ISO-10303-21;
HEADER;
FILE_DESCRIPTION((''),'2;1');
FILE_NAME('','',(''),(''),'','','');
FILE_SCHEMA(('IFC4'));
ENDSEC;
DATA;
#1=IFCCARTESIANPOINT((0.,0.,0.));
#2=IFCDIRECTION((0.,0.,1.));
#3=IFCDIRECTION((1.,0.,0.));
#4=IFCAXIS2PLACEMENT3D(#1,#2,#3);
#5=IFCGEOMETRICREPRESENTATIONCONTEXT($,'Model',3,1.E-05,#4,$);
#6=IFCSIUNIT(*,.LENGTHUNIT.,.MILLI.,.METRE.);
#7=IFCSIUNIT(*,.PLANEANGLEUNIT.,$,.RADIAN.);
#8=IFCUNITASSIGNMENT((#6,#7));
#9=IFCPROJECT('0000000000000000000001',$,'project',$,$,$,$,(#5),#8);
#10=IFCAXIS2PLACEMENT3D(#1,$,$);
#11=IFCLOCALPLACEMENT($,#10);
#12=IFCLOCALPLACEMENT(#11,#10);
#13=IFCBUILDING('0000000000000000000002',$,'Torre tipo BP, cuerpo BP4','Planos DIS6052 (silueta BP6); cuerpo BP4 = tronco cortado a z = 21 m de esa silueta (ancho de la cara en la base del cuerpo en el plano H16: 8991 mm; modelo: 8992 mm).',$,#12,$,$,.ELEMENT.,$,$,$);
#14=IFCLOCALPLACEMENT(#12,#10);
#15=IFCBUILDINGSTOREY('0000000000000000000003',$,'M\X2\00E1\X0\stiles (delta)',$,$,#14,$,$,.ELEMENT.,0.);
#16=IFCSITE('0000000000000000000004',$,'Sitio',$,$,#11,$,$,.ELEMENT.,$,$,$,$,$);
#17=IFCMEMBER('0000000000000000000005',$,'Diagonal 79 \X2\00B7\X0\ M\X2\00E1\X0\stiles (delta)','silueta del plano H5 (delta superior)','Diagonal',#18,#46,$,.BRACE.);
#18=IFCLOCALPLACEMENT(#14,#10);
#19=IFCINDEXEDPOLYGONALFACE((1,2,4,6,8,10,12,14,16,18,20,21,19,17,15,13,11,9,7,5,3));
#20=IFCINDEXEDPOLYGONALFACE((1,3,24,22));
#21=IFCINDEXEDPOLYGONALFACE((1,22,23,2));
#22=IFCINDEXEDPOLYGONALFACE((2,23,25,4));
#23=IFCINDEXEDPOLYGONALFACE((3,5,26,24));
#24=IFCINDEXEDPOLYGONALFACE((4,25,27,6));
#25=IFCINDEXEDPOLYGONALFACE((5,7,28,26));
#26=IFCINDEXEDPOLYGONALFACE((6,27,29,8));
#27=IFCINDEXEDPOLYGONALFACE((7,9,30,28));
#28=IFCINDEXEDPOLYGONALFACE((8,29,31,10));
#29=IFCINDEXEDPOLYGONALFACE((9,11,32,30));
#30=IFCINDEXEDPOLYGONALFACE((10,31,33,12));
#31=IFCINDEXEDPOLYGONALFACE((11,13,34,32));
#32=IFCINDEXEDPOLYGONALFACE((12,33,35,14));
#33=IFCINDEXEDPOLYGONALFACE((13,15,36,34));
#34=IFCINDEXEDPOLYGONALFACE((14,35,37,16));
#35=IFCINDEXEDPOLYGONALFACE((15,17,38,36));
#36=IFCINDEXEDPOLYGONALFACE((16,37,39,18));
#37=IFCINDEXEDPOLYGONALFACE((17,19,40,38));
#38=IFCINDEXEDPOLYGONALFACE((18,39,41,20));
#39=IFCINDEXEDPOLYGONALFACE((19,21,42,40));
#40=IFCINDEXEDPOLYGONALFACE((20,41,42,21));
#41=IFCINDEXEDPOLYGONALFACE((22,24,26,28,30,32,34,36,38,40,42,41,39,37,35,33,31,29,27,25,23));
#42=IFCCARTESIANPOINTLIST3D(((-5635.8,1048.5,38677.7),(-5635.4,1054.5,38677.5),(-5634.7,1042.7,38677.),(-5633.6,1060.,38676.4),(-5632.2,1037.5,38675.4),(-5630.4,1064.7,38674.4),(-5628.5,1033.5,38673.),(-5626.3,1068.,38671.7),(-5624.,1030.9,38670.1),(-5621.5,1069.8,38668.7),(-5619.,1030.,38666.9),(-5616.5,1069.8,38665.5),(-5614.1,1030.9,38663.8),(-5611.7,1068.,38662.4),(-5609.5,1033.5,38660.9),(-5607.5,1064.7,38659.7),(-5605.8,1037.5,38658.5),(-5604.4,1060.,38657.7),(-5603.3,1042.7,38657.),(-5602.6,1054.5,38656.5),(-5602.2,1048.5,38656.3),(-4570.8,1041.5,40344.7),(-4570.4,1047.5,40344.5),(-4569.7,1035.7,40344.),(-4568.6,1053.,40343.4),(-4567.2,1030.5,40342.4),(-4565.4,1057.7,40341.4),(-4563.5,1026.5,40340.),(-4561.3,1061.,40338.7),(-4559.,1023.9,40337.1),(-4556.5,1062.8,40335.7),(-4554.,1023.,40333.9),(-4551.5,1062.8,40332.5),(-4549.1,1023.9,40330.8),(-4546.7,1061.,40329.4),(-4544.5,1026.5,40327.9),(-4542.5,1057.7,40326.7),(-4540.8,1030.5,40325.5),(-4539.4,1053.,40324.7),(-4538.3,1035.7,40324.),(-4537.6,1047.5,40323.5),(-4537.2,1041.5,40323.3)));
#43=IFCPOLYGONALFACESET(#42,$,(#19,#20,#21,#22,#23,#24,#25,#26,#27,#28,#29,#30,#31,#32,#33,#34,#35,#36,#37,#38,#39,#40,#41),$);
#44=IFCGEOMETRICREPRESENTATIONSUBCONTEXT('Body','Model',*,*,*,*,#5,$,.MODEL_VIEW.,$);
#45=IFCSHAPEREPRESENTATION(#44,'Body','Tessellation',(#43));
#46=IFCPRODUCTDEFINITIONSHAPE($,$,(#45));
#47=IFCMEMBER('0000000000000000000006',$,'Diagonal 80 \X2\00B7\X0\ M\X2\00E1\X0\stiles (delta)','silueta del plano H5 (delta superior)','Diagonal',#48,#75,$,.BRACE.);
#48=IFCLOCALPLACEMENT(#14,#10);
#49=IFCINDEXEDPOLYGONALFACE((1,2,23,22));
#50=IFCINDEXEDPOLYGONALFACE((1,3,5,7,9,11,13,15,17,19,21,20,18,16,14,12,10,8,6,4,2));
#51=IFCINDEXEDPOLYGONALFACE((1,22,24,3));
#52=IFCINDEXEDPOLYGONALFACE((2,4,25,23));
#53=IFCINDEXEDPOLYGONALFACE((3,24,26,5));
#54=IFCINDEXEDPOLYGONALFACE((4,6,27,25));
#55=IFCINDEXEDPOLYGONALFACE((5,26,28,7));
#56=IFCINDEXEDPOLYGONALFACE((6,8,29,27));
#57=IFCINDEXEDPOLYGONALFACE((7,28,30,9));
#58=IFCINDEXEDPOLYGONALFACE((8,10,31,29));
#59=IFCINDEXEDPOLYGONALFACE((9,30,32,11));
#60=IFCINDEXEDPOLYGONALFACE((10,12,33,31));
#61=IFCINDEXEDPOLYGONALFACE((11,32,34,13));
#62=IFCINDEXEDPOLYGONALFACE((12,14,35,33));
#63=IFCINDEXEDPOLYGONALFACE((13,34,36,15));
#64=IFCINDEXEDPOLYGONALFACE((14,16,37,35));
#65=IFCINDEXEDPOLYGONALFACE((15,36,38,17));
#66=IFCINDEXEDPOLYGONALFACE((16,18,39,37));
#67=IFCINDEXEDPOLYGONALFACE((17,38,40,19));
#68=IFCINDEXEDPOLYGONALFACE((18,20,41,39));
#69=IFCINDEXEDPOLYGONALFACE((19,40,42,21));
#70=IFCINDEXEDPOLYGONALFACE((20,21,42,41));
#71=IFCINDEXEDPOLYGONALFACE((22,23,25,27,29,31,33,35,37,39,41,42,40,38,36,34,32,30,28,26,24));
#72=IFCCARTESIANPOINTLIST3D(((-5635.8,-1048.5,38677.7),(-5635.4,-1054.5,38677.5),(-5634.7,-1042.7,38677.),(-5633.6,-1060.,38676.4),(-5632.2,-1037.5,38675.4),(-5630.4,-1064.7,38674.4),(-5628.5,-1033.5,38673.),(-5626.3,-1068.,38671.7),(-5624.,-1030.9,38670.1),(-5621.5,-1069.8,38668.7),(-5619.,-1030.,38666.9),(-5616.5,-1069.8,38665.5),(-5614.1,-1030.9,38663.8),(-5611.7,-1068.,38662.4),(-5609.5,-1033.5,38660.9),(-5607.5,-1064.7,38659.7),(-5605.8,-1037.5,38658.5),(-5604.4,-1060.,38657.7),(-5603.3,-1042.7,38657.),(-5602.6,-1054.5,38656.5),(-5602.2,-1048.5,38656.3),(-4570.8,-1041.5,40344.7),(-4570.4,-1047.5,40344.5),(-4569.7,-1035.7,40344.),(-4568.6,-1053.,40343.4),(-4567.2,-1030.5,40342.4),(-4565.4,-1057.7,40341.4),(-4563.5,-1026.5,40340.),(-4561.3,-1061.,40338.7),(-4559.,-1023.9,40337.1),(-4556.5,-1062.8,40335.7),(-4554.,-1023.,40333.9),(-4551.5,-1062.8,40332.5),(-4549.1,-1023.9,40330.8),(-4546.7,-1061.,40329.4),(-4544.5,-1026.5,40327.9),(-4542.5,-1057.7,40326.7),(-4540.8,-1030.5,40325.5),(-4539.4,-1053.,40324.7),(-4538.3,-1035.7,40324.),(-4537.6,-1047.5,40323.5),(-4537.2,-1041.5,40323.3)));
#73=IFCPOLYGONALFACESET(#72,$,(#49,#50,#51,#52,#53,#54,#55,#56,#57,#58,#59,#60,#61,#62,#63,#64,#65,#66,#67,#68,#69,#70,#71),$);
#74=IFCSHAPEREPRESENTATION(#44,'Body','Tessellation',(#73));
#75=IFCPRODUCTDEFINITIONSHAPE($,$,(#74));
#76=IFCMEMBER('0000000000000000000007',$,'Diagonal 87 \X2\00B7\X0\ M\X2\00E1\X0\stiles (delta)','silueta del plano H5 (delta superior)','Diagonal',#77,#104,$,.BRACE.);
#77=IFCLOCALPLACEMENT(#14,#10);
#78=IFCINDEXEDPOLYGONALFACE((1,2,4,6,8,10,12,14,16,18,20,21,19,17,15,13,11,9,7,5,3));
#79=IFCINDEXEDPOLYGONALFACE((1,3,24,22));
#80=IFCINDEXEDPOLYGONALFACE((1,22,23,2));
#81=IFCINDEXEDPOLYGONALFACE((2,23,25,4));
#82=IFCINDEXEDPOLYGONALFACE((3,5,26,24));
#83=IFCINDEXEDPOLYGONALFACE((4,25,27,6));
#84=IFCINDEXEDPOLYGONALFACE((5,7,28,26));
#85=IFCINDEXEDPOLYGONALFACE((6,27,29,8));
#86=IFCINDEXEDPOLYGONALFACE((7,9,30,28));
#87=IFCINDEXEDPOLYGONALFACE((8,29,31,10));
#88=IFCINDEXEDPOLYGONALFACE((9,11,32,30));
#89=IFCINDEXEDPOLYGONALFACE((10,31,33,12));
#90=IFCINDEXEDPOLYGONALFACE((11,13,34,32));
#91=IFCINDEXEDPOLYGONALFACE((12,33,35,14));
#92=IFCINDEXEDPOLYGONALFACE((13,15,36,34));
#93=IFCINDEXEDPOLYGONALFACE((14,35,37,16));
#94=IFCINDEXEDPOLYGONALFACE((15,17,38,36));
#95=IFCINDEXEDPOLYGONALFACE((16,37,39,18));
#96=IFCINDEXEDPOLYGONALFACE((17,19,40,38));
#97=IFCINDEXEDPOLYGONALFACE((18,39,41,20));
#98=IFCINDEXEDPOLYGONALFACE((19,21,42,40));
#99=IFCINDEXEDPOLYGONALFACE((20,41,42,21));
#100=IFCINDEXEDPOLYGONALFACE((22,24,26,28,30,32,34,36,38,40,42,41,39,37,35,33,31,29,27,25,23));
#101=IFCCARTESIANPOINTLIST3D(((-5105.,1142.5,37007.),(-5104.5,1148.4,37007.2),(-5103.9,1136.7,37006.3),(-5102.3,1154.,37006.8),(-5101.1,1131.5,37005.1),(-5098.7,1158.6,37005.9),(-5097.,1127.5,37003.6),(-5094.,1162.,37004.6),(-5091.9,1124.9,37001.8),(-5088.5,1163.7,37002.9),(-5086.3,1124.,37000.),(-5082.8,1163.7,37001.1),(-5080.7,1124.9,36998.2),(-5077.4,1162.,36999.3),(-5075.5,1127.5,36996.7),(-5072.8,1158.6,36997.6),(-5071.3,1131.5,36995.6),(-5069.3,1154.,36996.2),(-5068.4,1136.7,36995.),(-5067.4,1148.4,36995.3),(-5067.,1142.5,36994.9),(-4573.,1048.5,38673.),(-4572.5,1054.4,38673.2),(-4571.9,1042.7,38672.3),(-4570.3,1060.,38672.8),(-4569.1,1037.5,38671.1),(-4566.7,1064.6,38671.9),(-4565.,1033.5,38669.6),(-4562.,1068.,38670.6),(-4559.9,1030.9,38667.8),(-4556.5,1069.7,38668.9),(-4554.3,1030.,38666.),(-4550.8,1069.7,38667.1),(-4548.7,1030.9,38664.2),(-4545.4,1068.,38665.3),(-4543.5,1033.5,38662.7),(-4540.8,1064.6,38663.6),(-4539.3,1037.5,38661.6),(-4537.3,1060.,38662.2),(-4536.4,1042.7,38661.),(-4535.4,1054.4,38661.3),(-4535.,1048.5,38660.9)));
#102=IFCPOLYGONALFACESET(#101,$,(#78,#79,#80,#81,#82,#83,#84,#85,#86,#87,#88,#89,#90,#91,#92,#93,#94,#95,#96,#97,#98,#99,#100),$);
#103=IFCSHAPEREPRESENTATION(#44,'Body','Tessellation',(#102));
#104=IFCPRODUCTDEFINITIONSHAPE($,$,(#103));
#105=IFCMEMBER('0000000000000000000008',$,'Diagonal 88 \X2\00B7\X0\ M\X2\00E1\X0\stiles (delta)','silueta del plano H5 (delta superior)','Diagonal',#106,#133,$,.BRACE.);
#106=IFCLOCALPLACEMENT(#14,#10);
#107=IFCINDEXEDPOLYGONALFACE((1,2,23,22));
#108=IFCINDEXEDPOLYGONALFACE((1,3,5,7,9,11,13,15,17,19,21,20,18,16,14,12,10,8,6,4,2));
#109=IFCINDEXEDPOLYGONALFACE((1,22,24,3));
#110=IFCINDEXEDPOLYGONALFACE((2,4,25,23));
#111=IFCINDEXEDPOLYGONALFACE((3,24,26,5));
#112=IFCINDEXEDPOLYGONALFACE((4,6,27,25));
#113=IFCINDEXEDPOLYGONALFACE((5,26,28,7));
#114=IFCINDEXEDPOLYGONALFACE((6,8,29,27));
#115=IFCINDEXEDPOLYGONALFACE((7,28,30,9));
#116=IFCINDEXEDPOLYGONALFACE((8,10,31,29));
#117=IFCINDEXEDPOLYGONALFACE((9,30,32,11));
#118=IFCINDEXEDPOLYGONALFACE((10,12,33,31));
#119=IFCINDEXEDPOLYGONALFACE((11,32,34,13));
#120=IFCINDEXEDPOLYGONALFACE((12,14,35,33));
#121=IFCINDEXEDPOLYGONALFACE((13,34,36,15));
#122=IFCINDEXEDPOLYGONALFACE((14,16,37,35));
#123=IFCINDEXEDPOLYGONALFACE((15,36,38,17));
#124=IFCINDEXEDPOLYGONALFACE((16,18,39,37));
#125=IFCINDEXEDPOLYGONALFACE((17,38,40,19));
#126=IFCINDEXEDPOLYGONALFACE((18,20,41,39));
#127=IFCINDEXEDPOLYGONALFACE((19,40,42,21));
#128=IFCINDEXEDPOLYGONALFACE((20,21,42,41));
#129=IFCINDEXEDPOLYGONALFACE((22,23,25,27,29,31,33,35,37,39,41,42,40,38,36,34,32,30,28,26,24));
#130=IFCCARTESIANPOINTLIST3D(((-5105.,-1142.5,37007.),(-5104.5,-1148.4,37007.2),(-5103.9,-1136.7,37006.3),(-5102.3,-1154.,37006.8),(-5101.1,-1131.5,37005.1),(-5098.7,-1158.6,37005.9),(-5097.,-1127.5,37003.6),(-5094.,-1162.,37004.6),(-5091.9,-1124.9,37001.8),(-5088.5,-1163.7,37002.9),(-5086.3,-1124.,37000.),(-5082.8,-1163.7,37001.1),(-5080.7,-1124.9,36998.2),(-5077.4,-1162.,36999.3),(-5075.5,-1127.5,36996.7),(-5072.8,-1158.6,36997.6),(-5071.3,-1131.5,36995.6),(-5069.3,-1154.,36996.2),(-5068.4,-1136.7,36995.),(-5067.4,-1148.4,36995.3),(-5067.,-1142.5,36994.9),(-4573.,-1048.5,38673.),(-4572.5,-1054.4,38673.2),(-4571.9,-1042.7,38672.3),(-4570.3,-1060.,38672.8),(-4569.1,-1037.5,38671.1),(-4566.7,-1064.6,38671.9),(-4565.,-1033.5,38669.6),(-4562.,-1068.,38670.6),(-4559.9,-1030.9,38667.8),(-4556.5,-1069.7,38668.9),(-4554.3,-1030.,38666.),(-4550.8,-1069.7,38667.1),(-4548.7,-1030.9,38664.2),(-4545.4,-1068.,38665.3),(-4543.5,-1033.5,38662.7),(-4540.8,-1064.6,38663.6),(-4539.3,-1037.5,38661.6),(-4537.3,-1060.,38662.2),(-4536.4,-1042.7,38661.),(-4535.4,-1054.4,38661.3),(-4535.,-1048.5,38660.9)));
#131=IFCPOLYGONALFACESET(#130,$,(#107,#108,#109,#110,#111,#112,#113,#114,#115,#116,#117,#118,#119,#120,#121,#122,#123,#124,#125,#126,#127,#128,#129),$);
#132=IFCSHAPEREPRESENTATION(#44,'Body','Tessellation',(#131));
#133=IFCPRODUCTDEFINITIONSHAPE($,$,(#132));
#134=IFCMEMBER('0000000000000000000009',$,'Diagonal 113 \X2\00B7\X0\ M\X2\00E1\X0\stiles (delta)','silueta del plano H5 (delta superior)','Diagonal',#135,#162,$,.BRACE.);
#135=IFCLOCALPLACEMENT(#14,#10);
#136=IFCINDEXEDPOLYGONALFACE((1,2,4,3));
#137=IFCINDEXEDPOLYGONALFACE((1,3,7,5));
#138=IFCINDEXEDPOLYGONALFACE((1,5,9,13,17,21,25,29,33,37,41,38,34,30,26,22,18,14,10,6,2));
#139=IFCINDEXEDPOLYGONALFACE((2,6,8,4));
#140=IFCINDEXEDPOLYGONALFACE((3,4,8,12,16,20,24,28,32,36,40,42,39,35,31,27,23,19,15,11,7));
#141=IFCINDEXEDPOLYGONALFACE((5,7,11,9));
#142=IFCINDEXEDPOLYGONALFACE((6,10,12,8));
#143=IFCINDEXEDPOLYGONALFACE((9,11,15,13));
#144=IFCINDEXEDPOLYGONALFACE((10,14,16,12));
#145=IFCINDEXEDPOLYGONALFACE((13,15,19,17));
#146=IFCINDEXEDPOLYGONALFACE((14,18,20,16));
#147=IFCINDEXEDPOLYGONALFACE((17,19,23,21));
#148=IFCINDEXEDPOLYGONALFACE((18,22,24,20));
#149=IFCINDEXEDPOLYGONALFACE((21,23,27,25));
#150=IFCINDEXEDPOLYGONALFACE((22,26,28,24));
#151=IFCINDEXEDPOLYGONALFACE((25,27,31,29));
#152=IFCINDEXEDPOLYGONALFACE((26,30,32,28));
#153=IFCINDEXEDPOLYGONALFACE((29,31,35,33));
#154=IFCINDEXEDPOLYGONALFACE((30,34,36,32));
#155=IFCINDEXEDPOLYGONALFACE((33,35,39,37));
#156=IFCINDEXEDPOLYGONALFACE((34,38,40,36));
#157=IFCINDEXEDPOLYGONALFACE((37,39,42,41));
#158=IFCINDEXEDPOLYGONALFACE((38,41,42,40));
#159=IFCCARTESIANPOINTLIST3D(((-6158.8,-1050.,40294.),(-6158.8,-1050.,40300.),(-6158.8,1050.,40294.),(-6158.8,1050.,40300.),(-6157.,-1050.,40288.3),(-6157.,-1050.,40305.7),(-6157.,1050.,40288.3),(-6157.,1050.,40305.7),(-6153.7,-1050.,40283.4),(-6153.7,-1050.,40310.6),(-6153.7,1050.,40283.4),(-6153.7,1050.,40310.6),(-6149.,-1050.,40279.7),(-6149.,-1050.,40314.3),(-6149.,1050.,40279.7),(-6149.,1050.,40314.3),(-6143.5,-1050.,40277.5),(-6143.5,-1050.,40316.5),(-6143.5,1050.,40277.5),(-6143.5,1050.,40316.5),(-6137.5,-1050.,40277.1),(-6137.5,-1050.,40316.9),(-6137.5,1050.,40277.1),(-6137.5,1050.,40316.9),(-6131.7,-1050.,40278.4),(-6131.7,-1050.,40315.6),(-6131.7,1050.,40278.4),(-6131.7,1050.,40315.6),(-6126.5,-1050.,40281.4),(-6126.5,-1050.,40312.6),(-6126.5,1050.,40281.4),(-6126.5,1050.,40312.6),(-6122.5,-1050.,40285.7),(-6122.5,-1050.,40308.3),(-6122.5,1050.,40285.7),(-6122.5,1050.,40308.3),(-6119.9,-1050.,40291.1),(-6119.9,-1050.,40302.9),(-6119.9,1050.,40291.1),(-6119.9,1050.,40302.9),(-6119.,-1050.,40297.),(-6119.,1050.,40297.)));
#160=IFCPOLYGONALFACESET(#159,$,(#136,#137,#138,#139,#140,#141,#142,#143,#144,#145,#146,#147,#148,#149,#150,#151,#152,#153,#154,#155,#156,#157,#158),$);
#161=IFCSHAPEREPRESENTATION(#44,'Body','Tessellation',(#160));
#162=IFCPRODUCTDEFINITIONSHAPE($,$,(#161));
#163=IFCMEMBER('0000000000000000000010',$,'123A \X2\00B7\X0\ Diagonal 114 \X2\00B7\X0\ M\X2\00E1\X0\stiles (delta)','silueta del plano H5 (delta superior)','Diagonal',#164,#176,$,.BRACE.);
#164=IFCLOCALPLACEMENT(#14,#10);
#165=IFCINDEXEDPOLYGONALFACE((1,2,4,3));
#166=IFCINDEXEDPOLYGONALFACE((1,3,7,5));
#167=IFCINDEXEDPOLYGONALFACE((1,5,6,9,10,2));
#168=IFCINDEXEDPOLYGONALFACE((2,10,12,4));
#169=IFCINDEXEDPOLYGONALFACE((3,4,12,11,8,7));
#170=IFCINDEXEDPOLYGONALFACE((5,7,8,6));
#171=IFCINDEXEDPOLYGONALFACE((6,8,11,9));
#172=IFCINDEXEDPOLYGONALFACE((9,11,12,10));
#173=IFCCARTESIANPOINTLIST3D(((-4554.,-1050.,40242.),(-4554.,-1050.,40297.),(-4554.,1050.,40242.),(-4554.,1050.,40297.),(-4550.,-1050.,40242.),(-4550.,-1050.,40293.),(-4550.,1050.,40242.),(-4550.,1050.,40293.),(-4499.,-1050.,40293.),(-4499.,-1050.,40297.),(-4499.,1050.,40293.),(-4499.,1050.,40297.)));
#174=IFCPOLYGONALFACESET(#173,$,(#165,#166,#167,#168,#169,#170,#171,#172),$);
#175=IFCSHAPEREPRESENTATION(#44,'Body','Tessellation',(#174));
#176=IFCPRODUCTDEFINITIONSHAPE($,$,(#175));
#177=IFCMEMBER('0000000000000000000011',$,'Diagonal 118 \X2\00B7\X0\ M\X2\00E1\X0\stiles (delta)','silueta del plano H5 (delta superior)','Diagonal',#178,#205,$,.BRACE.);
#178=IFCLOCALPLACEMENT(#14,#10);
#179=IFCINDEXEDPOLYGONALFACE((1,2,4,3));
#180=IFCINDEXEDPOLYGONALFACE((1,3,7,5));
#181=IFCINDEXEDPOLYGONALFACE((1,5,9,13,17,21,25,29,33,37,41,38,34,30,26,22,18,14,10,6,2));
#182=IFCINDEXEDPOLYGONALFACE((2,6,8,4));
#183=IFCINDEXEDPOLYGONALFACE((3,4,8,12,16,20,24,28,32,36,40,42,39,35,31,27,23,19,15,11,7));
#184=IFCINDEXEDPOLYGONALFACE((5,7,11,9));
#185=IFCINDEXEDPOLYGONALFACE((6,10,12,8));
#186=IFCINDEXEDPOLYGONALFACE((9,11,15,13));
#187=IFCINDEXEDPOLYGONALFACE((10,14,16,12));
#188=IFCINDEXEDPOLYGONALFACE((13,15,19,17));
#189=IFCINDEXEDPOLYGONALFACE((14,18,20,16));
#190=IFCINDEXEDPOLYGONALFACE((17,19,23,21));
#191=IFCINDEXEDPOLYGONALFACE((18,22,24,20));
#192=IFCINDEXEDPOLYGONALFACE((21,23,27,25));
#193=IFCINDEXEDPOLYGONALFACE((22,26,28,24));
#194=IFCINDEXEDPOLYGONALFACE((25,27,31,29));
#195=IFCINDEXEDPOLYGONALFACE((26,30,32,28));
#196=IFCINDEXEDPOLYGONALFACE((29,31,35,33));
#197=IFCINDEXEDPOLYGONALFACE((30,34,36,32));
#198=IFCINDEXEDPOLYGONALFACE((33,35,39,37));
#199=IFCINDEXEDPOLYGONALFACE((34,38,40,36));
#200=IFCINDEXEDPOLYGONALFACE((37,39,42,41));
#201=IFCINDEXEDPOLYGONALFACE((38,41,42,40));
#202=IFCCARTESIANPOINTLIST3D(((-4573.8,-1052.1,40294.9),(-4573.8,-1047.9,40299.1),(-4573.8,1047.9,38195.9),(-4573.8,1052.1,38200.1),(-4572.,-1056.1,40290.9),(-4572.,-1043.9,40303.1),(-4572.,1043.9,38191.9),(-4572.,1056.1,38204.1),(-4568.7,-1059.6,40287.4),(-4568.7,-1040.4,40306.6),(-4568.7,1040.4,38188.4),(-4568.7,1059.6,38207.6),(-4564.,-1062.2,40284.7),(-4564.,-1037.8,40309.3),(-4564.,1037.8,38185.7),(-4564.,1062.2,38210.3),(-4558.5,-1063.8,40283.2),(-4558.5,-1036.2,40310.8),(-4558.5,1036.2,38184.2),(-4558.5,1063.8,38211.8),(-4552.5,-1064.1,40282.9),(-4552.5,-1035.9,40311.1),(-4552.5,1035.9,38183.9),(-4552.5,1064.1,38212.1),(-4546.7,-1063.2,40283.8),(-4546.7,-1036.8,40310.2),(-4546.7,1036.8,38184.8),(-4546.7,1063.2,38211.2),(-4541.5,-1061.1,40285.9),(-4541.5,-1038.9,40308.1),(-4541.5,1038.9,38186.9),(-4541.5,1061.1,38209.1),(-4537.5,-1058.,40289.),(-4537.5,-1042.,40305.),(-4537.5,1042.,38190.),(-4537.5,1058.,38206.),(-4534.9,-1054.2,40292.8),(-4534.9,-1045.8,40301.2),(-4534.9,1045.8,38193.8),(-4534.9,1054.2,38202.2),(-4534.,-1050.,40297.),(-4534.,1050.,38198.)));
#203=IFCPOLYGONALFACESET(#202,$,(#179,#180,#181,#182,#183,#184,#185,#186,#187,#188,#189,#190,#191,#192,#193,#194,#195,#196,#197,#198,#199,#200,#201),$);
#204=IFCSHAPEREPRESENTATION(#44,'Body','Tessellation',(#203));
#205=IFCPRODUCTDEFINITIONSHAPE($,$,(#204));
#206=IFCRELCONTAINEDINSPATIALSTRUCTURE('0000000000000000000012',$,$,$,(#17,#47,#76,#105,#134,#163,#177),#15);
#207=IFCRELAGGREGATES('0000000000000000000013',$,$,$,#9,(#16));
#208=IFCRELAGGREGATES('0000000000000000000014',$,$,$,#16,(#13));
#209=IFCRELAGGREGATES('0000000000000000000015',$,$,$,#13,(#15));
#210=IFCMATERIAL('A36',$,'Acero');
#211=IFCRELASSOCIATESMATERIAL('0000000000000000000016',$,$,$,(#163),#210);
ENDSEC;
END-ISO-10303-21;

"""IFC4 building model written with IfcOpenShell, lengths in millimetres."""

from ifc_helpers import new_model, si_unit, frame, frame_2d, origin, origin_with_axes, place, context, subcontext, project, spatial, circle, l_section, extrude, material, element, save


model = new_model("IFC4")

# Units and contexts
model_context = context("Model", 3, precision=1e-05, world=origin_with_axes())
body_context = subcontext(model_context, "Body", "Model", "MODEL_VIEW")
ifc_project = project(units=[si_unit("LENGTHUNIT", "METRE", prefix="MILLI"), si_unit("PLANEANGLEUNIT", "RADIAN")], contexts=[model_context])

# Site, building, storey
site_placement = place(None, origin())
site = spatial("IfcSite", under=ifc_project, at=site_placement, Name="Sitio", CompositionType="ELEMENT")
building_placement = place(site_placement, origin())
building = spatial("IfcBuilding", under=site, at=building_placement, Name="Torre tipo BP, cuerpo BP4", Description="Planos DIS6052 (silueta BP6); cuerpo BP4 = tronco cortado a z = 21 m de esa silueta (ancho de la cara en la base del cuerpo en el plano H16: 8991 mm; modelo: 8992 mm).", CompositionType="ELEMENT")
storey_placement = place(building_placement, origin())
storey = spatial("IfcBuildingStorey", under=building, at=storey_placement, Name="Mástiles (delta)", CompositionType="ELEMENT", Elevation=0.0)

# Members
for number, where, z_axis, x_axis, name in (
    (1, (-4554.0, 1043.0, 40334.0), (-0.538376, 0.003539, -0.842697), (-0.001905, -0.999994, -0.002982), "Diagonal 79 · Mástiles (delta)"),
    (2, (-4554.0, -1043.0, 40334.0), (-0.538376, -0.003539, -0.842697), (-0.001905, 0.999994, -0.002982), "Diagonal 80 · Mástiles (delta)"),
):
    element("IfcMember", number, at=place(storey_placement, frame(where, z_axis=z_axis, x_axis=x_axis)), inside=storey, Name=name, Description="silueta del plano H5 (delta superior)", ObjectType="Diagonal", PredefinedType="BRACE", context=body_context, shape_type="SweptSolid", body=[
        extrude(circle(Radius=20.0), None, (0.0, 0.0, 1.0), 1978.2),
    ])
for number, where, z_axis, x_axis, name in (
    (3, (-4554.0, 1050.0, 38667.0), (-0.303756, 0.053671, -0.951237), (-0.016327, -0.998559, -0.051128), "Diagonal 87 · Mástiles (delta)"),
    (4, (-4554.0, -1050.0, 38667.0), (-0.303756, -0.053671, -0.951237), (-0.016327, 0.998559, -0.051128), "Diagonal 88 · Mástiles (delta)"),
):
    element("IfcMember", number, at=place(storey_placement, frame(where, z_axis=z_axis, x_axis=x_axis)), inside=storey, Name=name, Description="silueta del plano H5 (delta superior)", ObjectType="Diagonal", PredefinedType="BRACE", context=body_context, shape_type="SweptSolid", body=[
        extrude(circle(Radius=20.0), None, (0.0, 0.0, 1.0), 1751.4),
    ])
member_1_placement = place(storey_placement, frame((-6139.0, -1050.0, 40297.0), z_axis=(0.0, 1.0, 0.0), x_axis=(1.0, 0.0, 0.0)))
element("IfcMember", 5, at=member_1_placement, inside=storey, Name="Diagonal 113 · Mástiles (delta)", Description="silueta del plano H5 (delta superior)", ObjectType="Diagonal", PredefinedType="BRACE", context=body_context, shape_type="SweptSolid", body=[
    extrude(circle(Radius=20.0), None, (0.0, 0.0, 1.0), 2100.0),
])
ifc_material_1 = material(Name="A36", Category="Acero")
member_2_placement = place(storey_placement, frame((-4554.0, -1050.0, 40297.0), z_axis=(0.0, 1.0, 0.0), x_axis=(1.0, 0.0, 0.0)))
element("IfcMember", 6, at=member_2_placement, inside=storey, material=ifc_material_1, Name="123A · Diagonal 114 · Mástiles (delta)", Description="silueta del plano H5 (delta superior)", ObjectType="Diagonal", PredefinedType="BRACE", context=body_context, shape_type="SweptSolid", body=[
    extrude(l_section(Depth=55.0, Width=55.0, Thickness=4.0, at=frame_2d((27.5, 27.5))), None, (0.0, 0.0, 1.0), 2100.0),
])
member_3_placement = place(storey_placement, frame((-4554.0, -1050.0, 40297.0), z_axis=(0.0, 0.707275, -0.706938), x_axis=(1.0, 0.0, 0.0)))
element("IfcMember", 7, at=member_3_placement, inside=storey, Name="Diagonal 118 · Mástiles (delta)", Description="silueta del plano H5 (delta superior)", ObjectType="Diagonal", PredefinedType="BRACE", context=body_context, shape_type="SweptSolid", body=[
    extrude(circle(Radius=20.0), None, (0.0, 0.0, 1.0), 2969.1),
])

save(model, "model.ifc")
